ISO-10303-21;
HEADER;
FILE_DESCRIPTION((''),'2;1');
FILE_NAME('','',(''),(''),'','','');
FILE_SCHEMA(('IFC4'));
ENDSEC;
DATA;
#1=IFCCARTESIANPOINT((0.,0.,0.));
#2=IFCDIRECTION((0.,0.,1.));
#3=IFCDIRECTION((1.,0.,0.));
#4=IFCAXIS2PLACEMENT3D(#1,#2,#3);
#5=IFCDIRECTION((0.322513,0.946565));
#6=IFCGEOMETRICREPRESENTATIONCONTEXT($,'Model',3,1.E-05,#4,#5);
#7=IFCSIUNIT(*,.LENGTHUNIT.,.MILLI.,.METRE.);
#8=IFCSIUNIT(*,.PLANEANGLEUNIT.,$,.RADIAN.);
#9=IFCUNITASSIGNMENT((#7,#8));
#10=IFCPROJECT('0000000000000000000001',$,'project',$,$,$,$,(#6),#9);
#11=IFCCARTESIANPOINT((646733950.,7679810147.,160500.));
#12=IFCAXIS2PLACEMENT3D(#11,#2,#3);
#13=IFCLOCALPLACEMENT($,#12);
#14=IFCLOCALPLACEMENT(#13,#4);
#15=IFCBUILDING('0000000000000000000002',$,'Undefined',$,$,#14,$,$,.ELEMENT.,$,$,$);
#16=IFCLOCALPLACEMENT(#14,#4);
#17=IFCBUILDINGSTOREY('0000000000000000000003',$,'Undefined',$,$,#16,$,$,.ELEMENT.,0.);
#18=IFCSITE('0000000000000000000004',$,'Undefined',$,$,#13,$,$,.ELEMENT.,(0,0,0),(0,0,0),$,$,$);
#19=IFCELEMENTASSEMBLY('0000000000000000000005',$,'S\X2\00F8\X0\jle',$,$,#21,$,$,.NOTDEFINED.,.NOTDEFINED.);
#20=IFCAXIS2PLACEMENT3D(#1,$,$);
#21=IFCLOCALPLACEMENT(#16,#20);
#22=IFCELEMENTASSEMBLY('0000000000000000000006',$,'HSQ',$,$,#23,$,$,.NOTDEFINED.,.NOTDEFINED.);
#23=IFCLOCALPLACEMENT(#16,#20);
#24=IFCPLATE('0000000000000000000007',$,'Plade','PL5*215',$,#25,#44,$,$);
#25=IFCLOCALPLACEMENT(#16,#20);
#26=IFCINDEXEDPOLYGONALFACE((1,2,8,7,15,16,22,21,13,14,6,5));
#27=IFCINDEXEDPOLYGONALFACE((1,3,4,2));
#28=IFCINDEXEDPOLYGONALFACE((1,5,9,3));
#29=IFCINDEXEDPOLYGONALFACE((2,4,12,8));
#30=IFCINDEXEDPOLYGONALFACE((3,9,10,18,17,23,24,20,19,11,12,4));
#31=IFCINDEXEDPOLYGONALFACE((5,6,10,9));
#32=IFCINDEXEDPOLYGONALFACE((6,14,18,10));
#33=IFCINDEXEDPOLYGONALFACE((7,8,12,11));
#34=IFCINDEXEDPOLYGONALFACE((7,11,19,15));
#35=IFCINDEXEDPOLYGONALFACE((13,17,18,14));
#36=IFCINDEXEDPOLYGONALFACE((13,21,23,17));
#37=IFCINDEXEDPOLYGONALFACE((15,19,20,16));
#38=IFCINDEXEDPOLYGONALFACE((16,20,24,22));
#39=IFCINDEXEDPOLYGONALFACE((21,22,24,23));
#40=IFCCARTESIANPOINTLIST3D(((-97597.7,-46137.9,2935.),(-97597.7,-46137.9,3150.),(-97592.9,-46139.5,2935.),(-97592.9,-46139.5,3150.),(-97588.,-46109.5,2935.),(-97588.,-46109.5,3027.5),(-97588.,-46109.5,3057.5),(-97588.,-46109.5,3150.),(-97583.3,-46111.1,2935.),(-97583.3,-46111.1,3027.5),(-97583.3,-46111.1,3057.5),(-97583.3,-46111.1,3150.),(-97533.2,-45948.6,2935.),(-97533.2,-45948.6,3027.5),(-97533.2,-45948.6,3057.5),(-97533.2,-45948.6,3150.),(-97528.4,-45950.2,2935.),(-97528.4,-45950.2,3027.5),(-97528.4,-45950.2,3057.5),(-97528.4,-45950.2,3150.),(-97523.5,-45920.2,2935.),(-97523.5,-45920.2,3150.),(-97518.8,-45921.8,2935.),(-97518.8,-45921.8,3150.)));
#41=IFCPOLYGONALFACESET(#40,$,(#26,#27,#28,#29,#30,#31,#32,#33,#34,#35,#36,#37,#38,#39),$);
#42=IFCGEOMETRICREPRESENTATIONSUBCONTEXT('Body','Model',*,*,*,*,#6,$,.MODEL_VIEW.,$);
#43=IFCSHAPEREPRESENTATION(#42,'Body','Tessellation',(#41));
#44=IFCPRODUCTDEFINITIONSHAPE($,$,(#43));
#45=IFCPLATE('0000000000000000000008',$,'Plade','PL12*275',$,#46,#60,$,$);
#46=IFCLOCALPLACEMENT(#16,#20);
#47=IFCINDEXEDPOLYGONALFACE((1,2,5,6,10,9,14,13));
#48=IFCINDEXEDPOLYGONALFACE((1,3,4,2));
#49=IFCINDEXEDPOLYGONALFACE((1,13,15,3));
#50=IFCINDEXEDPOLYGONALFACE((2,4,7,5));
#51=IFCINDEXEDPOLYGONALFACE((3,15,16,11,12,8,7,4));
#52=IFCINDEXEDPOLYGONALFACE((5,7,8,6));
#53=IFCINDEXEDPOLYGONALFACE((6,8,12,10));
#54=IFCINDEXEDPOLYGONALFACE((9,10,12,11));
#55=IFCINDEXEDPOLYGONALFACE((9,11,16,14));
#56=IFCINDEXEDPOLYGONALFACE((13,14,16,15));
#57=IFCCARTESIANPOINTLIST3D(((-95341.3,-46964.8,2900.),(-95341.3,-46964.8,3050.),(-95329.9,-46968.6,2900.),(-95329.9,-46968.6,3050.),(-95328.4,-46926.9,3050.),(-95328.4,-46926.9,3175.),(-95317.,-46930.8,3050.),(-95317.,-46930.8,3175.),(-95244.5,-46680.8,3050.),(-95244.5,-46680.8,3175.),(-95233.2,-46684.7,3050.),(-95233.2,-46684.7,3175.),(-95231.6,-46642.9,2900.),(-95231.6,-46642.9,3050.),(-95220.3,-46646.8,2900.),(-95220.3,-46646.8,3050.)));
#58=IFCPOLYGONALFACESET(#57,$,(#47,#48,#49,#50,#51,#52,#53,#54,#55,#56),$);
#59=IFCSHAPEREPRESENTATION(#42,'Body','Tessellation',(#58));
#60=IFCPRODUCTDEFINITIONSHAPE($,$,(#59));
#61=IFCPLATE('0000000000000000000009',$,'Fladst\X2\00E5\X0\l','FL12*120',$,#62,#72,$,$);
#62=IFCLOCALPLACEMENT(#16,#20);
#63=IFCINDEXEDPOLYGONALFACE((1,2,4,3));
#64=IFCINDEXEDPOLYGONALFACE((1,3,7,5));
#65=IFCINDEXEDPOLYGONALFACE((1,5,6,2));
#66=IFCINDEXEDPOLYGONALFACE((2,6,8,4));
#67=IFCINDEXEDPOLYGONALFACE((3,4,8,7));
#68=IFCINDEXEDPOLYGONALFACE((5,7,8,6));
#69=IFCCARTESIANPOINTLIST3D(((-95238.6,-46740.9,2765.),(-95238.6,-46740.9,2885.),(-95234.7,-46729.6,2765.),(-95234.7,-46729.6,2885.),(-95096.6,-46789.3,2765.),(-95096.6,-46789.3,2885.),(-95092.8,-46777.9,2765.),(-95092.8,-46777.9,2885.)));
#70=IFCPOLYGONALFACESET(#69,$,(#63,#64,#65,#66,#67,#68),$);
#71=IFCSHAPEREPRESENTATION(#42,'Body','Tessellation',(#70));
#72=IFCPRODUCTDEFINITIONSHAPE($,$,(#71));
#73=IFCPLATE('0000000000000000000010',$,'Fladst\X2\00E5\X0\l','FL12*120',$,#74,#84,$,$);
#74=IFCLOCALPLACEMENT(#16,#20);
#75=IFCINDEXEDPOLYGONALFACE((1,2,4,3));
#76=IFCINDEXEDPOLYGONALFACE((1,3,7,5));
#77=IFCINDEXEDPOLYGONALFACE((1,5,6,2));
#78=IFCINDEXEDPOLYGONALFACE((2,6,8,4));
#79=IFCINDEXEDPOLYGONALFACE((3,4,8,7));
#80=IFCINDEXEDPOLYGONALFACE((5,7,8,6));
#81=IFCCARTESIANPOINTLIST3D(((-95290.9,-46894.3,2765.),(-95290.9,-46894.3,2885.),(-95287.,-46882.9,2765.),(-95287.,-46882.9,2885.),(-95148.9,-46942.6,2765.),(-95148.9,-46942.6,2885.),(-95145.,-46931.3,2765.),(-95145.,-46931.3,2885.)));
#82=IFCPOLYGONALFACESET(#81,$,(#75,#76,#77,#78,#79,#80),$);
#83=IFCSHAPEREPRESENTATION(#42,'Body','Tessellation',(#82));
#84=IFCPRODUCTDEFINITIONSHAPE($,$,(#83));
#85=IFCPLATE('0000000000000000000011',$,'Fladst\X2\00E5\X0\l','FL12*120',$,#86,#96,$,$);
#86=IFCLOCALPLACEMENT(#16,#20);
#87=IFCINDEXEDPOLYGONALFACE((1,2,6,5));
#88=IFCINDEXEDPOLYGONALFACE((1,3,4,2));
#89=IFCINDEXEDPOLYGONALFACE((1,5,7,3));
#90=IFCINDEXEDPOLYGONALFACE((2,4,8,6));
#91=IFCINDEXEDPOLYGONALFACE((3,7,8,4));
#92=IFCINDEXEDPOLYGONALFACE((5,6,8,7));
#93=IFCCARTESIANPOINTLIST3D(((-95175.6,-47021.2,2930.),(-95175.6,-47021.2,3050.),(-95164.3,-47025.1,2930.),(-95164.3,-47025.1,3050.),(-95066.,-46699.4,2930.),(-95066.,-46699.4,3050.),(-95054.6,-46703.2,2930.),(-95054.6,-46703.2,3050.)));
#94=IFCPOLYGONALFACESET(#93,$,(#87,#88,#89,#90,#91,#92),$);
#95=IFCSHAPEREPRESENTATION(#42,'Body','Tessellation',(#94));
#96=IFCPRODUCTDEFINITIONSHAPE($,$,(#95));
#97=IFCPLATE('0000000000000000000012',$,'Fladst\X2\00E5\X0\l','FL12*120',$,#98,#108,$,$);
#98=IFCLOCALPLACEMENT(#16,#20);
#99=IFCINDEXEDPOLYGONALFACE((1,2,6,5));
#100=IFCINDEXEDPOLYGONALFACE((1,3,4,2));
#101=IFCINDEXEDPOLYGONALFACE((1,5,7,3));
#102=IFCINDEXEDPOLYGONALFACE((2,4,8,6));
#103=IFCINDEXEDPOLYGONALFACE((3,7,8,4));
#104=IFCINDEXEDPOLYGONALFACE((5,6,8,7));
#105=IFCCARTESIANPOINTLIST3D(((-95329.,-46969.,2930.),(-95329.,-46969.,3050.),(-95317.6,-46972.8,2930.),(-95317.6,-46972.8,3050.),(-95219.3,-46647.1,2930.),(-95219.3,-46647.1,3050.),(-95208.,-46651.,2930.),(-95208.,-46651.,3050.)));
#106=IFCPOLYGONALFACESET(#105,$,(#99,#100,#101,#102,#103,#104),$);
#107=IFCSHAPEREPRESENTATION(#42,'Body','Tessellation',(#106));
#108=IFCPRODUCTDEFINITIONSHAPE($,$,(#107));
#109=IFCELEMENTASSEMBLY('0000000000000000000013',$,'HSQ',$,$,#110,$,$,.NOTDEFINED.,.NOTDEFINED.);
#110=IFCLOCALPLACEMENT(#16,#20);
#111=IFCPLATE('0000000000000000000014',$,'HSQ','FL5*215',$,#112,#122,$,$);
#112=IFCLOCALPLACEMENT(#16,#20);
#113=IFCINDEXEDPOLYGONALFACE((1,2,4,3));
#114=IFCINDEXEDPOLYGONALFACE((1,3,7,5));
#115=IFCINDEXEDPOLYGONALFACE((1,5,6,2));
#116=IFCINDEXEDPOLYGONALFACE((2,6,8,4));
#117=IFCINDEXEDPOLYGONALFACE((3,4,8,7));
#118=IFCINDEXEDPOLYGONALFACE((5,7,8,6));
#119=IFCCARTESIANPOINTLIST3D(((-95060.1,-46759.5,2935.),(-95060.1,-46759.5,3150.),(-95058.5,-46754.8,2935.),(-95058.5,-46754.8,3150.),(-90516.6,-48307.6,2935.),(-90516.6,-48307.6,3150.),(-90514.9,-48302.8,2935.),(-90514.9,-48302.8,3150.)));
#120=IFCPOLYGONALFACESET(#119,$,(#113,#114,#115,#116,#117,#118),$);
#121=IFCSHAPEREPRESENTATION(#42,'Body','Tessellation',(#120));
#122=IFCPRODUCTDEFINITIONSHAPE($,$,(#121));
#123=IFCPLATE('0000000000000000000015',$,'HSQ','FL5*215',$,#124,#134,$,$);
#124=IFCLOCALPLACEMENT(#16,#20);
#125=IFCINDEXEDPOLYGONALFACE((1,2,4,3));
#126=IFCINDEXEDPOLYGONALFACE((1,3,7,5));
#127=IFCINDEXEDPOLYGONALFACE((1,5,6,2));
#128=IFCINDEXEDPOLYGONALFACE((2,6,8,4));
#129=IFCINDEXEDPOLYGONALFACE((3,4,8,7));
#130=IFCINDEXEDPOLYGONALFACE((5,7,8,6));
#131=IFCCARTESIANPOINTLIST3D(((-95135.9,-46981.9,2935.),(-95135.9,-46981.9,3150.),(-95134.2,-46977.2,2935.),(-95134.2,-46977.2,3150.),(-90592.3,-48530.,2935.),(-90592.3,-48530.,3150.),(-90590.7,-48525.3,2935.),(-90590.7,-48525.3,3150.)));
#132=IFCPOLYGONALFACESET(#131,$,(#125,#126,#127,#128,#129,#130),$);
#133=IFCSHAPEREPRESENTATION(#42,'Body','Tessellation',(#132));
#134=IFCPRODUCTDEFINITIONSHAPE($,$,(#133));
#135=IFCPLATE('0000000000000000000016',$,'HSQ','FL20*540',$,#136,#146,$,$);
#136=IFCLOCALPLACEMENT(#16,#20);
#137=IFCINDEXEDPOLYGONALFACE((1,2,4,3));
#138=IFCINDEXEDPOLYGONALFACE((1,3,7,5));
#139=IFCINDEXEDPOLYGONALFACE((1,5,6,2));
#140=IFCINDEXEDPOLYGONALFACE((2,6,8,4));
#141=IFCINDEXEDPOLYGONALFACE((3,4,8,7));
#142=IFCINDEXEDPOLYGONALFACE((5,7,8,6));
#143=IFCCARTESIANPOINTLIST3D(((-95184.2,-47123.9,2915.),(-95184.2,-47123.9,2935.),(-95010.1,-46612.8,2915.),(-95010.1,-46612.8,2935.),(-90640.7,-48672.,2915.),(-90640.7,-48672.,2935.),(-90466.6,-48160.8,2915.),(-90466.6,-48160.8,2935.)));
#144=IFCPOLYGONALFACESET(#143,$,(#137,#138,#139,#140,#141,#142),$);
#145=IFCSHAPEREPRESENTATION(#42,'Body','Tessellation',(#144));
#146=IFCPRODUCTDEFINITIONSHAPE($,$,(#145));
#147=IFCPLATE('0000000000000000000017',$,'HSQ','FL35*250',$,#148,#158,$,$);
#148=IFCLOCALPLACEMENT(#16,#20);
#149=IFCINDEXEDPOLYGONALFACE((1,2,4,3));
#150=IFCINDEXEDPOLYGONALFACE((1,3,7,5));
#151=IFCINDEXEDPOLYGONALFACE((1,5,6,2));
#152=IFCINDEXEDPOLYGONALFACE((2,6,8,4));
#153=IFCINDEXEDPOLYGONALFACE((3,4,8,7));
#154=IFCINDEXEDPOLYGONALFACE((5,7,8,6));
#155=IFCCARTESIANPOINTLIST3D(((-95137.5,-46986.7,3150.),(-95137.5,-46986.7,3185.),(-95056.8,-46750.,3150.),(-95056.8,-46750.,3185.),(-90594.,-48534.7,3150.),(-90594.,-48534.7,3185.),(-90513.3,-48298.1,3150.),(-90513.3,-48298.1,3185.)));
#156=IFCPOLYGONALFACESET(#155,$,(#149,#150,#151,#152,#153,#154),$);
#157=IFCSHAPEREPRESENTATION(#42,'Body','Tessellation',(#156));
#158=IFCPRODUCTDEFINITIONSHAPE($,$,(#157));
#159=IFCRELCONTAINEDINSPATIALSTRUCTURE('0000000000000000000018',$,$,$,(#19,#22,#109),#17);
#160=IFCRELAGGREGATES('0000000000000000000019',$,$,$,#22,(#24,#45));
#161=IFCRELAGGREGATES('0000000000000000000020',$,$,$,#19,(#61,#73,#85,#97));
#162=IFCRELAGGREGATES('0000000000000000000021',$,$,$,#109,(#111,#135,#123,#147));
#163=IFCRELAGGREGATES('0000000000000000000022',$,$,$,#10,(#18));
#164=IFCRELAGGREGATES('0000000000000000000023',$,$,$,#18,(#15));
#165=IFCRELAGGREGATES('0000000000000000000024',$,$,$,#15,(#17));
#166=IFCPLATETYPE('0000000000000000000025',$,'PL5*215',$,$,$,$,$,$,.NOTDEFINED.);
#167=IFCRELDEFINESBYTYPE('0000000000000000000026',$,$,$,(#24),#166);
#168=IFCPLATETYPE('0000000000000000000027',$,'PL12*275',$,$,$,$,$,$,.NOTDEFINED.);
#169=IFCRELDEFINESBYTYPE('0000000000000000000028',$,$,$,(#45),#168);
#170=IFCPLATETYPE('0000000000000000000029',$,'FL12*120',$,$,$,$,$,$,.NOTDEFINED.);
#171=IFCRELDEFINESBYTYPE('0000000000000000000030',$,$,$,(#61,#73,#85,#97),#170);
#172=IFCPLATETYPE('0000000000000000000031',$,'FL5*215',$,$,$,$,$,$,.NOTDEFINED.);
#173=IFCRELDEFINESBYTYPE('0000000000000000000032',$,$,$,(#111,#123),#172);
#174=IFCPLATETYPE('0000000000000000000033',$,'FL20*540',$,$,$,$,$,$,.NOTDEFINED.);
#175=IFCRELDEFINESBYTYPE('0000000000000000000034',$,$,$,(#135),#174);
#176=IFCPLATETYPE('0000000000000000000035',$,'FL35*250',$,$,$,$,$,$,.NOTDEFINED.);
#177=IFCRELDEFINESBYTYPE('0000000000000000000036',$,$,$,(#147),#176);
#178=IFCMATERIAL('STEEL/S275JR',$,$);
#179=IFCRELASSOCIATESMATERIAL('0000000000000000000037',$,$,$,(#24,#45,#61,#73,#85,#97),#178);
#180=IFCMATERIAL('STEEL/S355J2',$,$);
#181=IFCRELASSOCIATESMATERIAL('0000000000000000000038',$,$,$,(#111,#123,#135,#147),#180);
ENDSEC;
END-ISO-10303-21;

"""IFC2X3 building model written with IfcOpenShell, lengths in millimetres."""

from ifc_helpers import new_model, si_unit, direction, frame, origin_with_axes, place, context, subcontext, project, spatial, polyline, outline, extrude, material, type_object, element, aggregate, save


model = new_model("IFC2X3")

# Units and contexts
model_context = context("Model", 3, precision=1e-05, world=origin_with_axes(), true_north=direction((0.322513, 0.946565)))
body_context = subcontext(model_context, "Body", "Model", "MODEL_VIEW")
ifc_project = project(units=[si_unit("LENGTHUNIT", "METRE", prefix="MILLI"), si_unit("PLANEANGLEUNIT", "RADIAN")], contexts=[model_context])

# Site, building, storey
site_placement = place(None, frame((646733950.0, 7679810147.0, 160500.0), z_axis=(0.0, 0.0, 1.0), x_axis=(1.0, 0.0, 0.0)))
site = spatial("IfcSite", under=ifc_project, at=site_placement, Name="Undefined", CompositionType="ELEMENT", RefLatitude=(0, 0, 0), RefLongitude=(0, 0, 0))
building_placement = place(site_placement, origin_with_axes())
building = spatial("IfcBuilding", under=site, at=building_placement, Name="Undefined", CompositionType="ELEMENT")
storey_placement = place(building_placement, origin_with_axes())
storey = spatial("IfcBuildingStorey", under=building, at=storey_placement, Name="Undefined", CompositionType="ELEMENT", Elevation=0.0)

# Element assembly
assembly_1_placement = place(storey_placement, origin_with_axes())
assembly_1 = element("IfcElementAssembly", 1, at=assembly_1_placement, inside=storey, Name="Søjle", AssemblyPlace="NOTDEFINED", PredefinedType="NOTDEFINED")

# Shared definitions
ifc_material_1 = material(Name="STEEL/S275JR")

# Element assembly, plates
assembly_2_placement = place(storey_placement, origin_with_axes())
assembly_2 = element("IfcElementAssembly", 2, at=assembly_2_placement, inside=storey, Name="HSQ", AssemblyPlace="NOTDEFINED", PredefinedType="NOTDEFINED")
plate_type_1 = type_object("IfcPlateType", Name="PL5*215", PredefinedType="NOTDEFINED")
plate_1_placement = place(assembly_2_placement, frame((-97595.3, -46138.7, 3150.0), z_axis=(0.946565, -0.322513, 0.0), x_axis=(0.0, 0.0, -1.0)))
plate_1 = element("IfcPlate", 3, at=plate_1_placement, type_object=plate_type_1, material=ifc_material_1, Name="Plade", Description="PL5*215", context=body_context, shape_type="SweptSolid", body=[
    extrude(outline(polyline([(0.0, 0.0), (215.0, 0.0), (215.0, 30.0), (122.5, 30.0), (122.5, 200.0), (215.0, 200.0), (215.0, 230.0), (0.0, 230.0), (0.0, 200.0), (92.5, 200.0), (92.5, 30.0), (0.0, 30.0), (0.0, 0.0)])), frame((0.0, 0.0, -2.5), z_axis=(0.0, 0.0, 1.0), x_axis=(1.0, 0.0, 0.0)), (0.0, 0.0, 1.0), 5.0),
])
plate_type_2 = type_object("IfcPlateType", Name="PL12*275", PredefinedType="NOTDEFINED")
plate_2_placement = place(assembly_2_placement, frame((-95226.0, -46644.9, 3175.0), z_axis=(0.946565, -0.322513, 0.0), x_axis=(-0.322513, -0.946565, 0.0)))
plate_2 = element("IfcPlate", 4, at=plate_2_placement, type_object=plate_type_2, material=ifc_material_1, Name="Plade", Description="PL12*275", context=body_context, shape_type="SweptSolid", body=[
    extrude(outline(polyline([(0.0, 125.0), (40.0, 125.0), (40.0, 0.0), (300.0, 0.0), (300.0, 125.0), (340.0, 125.0), (340.0, 275.0), (0.0, 275.0), (0.0, 125.0)])), frame((0.0, 0.0, -6.0), z_axis=(0.0, 0.0, 1.0), x_axis=(1.0, 0.0, 0.0)), (0.0, 0.0, 1.0), 12.0),
])

# Plates
plate_type_3 = type_object("IfcPlateType", Name="FL12*120", PredefinedType="NOTDEFINED")
plate_3_placement = place(assembly_1_placement, frame((-95094.7, -46783.6, 2885.0), z_axis=(-0.322513, -0.946565, 0.0), x_axis=(-0.946565, 0.322513, 0.0)))
plate_3 = element("IfcPlate", 5, at=plate_3_placement, type_object=plate_type_3, material=ifc_material_1, Name="Fladstål", Description="FL12*120", context=body_context, shape_type="SweptSolid", body=[
    extrude(outline(polyline([(0.0, 0.0), (150.0, 0.0), (150.0, 120.0), (0.0, 120.0), (0.0, 0.0)])), frame((0.0, 0.0, -6.0), z_axis=(0.0, 0.0, 1.0), x_axis=(1.0, 0.0, 0.0)), (0.0, 0.0, 1.0), 12.0),
])
plate_4_placement = place(assembly_1_placement, frame((-95146.9, -46937.0, 2885.0), z_axis=(-0.322513, -0.946565, 0.0), x_axis=(-0.946565, 0.322513, 0.0)))
plate_4 = element("IfcPlate", 6, at=plate_4_placement, type_object=plate_type_3, material=ifc_material_1, Name="Fladstål", Description="FL12*120", context=body_context, shape_type="SweptSolid", body=[
    extrude(outline(polyline([(0.0, 0.0), (150.0, 0.0), (150.0, 120.0), (0.0, 120.0), (0.0, 0.0)])), frame((0.0, 0.0, -6.0), z_axis=(0.0, 0.0, 1.0), x_axis=(1.0, 0.0, 0.0)), (0.0, 0.0, 1.0), 12.0),
])
plate_5_placement = place(assembly_1_placement, frame((-95060.3, -46701.3, 3050.0), z_axis=(0.946565, -0.322513, 0.0), x_axis=(-0.322513, -0.946565, 0.0)))
plate_5 = element("IfcPlate", 7, at=plate_5_placement, type_object=plate_type_3, material=ifc_material_1, Name="Fladstål", Description="FL12*120", context=body_context, shape_type="SweptSolid", body=[
    extrude(outline(polyline([(0.0, 0.0), (340.0, 0.0), (340.0, 120.0), (0.0, 120.0), (0.0, 0.0)])), frame((0.0, 0.0, -6.0), z_axis=(0.0, 0.0, 1.0), x_axis=(1.0, 0.0, 0.0)), (0.0, 0.0, 1.0), 12.0),
])
plate_6_placement = place(assembly_1_placement, frame((-95213.7, -46649.1, 3050.0), z_axis=(0.946565, -0.322513, 0.0), x_axis=(-0.322513, -0.946565, 0.0)))
plate_6 = element("IfcPlate", 8, at=plate_6_placement, type_object=plate_type_3, material=ifc_material_1, Name="Fladstål", Description="FL12*120", context=body_context, shape_type="SweptSolid", body=[
    extrude(outline(polyline([(0.0, 0.0), (340.0, 0.0), (340.0, 120.0), (0.0, 120.0), (0.0, 0.0)])), frame((0.0, 0.0, -6.0), z_axis=(0.0, 0.0, 1.0), x_axis=(1.0, 0.0, 0.0)), (0.0, 0.0, 1.0), 12.0),
])

# Element assembly, plates
assembly_3_placement = place(storey_placement, origin_with_axes())
assembly_3 = element("IfcElementAssembly", 9, at=assembly_3_placement, inside=storey, Name="HSQ", AssemblyPlace="NOTDEFINED", PredefinedType="NOTDEFINED")
ifc_material_2 = material(Name="STEEL/S355J2")
plate_type_4 = type_object("IfcPlateType", Name="FL5*215", PredefinedType="NOTDEFINED")
plate_7_placement = place(assembly_3_placement, frame((-95059.3, -46757.1, 3042.5), z_axis=(-0.322513, -0.946565, 0.0), x_axis=(0.946565, -0.322513, 0.0)))
plate_7 = element("IfcPlate", 10, at=plate_7_placement, type_object=plate_type_4, material=ifc_material_2, Name="HSQ", Description="FL5*215", context=body_context, shape_type="SweptSolid", body=[
    extrude(outline(polyline([(0.0, -107.5), (0.0, 107.5), (4800.0, 107.5), (4800.0, -107.5), (0.0, -107.5)])), frame((0.0, 0.0, -2.5), z_axis=(0.0, 0.0, 1.0), x_axis=(1.0, 0.0, 0.0)), (0.0, 0.0, 1.0), 5.0),
])
plate_8_placement = place(assembly_3_placement, frame((-95135.0, -46979.6, 3042.5), z_axis=(-0.322513, -0.946565, 0.0), x_axis=(0.946565, -0.322513, 0.0)))
plate_8 = element("IfcPlate", 11, at=plate_8_placement, type_object=plate_type_4, material=ifc_material_2, Name="HSQ", Description="FL5*215", context=body_context, shape_type="SweptSolid", body=[
    extrude(outline(polyline([(0.0, -107.5), (0.0, 107.5), (4800.0, 107.5), (4800.0, -107.5), (0.0, -107.5)])), frame((0.0, 0.0, -2.5), z_axis=(0.0, 0.0, 1.0), x_axis=(1.0, 0.0, 0.0)), (0.0, 0.0, 1.0), 5.0),
])
plate_type_5 = type_object("IfcPlateType", Name="FL20*540", PredefinedType="NOTDEFINED")
plate_9_placement = place(assembly_3_placement, frame((-95097.2, -46868.3, 2925.0), z_axis=(0.0, 0.0, 1.0), x_axis=(0.946565, -0.322513, 0.0)))
plate_9 = element("IfcPlate", 12, at=plate_9_placement, type_object=plate_type_5, material=ifc_material_2, Name="HSQ", Description="FL20*540", context=body_context, shape_type="SweptSolid", body=[
    extrude(outline(polyline([(0.0, -270.0), (0.0, 270.0), (4800.0, 270.0), (4800.0, -270.0), (0.0, -270.0)])), frame((0.0, 0.0, -10.0), z_axis=(0.0, 0.0, 1.0), x_axis=(1.0, 0.0, 0.0)), (0.0, 0.0, 1.0), 20.0),
])
plate_type_6 = type_object("IfcPlateType", Name="FL35*250", PredefinedType="NOTDEFINED")
plate_10_placement = place(assembly_3_placement, frame((-95097.2, -46868.3, 3167.5), z_axis=(0.0, 0.0, 1.0), x_axis=(0.946565, -0.322513, 0.0)))
plate_10 = element("IfcPlate", 13, at=plate_10_placement, type_object=plate_type_6, material=ifc_material_2, Name="HSQ", Description="FL35*250", context=body_context, shape_type="SweptSolid", body=[
    extrude(outline(polyline([(0.0, -125.0), (0.0, 125.0), (4800.0, 125.0), (4800.0, -125.0), (0.0, -125.0)])), frame((0.0, 0.0, -17.5), z_axis=(0.0, 0.0, 1.0), x_axis=(1.0, 0.0, 0.0)), (0.0, 0.0, 1.0), 35.0),
])

aggregate(assembly_2, [plate_1, plate_2])
aggregate(assembly_1, [plate_3, plate_4, plate_5, plate_6])
aggregate(assembly_3, [plate_7, plate_9, plate_8, plate_10])

save(model, "model.ifc")
